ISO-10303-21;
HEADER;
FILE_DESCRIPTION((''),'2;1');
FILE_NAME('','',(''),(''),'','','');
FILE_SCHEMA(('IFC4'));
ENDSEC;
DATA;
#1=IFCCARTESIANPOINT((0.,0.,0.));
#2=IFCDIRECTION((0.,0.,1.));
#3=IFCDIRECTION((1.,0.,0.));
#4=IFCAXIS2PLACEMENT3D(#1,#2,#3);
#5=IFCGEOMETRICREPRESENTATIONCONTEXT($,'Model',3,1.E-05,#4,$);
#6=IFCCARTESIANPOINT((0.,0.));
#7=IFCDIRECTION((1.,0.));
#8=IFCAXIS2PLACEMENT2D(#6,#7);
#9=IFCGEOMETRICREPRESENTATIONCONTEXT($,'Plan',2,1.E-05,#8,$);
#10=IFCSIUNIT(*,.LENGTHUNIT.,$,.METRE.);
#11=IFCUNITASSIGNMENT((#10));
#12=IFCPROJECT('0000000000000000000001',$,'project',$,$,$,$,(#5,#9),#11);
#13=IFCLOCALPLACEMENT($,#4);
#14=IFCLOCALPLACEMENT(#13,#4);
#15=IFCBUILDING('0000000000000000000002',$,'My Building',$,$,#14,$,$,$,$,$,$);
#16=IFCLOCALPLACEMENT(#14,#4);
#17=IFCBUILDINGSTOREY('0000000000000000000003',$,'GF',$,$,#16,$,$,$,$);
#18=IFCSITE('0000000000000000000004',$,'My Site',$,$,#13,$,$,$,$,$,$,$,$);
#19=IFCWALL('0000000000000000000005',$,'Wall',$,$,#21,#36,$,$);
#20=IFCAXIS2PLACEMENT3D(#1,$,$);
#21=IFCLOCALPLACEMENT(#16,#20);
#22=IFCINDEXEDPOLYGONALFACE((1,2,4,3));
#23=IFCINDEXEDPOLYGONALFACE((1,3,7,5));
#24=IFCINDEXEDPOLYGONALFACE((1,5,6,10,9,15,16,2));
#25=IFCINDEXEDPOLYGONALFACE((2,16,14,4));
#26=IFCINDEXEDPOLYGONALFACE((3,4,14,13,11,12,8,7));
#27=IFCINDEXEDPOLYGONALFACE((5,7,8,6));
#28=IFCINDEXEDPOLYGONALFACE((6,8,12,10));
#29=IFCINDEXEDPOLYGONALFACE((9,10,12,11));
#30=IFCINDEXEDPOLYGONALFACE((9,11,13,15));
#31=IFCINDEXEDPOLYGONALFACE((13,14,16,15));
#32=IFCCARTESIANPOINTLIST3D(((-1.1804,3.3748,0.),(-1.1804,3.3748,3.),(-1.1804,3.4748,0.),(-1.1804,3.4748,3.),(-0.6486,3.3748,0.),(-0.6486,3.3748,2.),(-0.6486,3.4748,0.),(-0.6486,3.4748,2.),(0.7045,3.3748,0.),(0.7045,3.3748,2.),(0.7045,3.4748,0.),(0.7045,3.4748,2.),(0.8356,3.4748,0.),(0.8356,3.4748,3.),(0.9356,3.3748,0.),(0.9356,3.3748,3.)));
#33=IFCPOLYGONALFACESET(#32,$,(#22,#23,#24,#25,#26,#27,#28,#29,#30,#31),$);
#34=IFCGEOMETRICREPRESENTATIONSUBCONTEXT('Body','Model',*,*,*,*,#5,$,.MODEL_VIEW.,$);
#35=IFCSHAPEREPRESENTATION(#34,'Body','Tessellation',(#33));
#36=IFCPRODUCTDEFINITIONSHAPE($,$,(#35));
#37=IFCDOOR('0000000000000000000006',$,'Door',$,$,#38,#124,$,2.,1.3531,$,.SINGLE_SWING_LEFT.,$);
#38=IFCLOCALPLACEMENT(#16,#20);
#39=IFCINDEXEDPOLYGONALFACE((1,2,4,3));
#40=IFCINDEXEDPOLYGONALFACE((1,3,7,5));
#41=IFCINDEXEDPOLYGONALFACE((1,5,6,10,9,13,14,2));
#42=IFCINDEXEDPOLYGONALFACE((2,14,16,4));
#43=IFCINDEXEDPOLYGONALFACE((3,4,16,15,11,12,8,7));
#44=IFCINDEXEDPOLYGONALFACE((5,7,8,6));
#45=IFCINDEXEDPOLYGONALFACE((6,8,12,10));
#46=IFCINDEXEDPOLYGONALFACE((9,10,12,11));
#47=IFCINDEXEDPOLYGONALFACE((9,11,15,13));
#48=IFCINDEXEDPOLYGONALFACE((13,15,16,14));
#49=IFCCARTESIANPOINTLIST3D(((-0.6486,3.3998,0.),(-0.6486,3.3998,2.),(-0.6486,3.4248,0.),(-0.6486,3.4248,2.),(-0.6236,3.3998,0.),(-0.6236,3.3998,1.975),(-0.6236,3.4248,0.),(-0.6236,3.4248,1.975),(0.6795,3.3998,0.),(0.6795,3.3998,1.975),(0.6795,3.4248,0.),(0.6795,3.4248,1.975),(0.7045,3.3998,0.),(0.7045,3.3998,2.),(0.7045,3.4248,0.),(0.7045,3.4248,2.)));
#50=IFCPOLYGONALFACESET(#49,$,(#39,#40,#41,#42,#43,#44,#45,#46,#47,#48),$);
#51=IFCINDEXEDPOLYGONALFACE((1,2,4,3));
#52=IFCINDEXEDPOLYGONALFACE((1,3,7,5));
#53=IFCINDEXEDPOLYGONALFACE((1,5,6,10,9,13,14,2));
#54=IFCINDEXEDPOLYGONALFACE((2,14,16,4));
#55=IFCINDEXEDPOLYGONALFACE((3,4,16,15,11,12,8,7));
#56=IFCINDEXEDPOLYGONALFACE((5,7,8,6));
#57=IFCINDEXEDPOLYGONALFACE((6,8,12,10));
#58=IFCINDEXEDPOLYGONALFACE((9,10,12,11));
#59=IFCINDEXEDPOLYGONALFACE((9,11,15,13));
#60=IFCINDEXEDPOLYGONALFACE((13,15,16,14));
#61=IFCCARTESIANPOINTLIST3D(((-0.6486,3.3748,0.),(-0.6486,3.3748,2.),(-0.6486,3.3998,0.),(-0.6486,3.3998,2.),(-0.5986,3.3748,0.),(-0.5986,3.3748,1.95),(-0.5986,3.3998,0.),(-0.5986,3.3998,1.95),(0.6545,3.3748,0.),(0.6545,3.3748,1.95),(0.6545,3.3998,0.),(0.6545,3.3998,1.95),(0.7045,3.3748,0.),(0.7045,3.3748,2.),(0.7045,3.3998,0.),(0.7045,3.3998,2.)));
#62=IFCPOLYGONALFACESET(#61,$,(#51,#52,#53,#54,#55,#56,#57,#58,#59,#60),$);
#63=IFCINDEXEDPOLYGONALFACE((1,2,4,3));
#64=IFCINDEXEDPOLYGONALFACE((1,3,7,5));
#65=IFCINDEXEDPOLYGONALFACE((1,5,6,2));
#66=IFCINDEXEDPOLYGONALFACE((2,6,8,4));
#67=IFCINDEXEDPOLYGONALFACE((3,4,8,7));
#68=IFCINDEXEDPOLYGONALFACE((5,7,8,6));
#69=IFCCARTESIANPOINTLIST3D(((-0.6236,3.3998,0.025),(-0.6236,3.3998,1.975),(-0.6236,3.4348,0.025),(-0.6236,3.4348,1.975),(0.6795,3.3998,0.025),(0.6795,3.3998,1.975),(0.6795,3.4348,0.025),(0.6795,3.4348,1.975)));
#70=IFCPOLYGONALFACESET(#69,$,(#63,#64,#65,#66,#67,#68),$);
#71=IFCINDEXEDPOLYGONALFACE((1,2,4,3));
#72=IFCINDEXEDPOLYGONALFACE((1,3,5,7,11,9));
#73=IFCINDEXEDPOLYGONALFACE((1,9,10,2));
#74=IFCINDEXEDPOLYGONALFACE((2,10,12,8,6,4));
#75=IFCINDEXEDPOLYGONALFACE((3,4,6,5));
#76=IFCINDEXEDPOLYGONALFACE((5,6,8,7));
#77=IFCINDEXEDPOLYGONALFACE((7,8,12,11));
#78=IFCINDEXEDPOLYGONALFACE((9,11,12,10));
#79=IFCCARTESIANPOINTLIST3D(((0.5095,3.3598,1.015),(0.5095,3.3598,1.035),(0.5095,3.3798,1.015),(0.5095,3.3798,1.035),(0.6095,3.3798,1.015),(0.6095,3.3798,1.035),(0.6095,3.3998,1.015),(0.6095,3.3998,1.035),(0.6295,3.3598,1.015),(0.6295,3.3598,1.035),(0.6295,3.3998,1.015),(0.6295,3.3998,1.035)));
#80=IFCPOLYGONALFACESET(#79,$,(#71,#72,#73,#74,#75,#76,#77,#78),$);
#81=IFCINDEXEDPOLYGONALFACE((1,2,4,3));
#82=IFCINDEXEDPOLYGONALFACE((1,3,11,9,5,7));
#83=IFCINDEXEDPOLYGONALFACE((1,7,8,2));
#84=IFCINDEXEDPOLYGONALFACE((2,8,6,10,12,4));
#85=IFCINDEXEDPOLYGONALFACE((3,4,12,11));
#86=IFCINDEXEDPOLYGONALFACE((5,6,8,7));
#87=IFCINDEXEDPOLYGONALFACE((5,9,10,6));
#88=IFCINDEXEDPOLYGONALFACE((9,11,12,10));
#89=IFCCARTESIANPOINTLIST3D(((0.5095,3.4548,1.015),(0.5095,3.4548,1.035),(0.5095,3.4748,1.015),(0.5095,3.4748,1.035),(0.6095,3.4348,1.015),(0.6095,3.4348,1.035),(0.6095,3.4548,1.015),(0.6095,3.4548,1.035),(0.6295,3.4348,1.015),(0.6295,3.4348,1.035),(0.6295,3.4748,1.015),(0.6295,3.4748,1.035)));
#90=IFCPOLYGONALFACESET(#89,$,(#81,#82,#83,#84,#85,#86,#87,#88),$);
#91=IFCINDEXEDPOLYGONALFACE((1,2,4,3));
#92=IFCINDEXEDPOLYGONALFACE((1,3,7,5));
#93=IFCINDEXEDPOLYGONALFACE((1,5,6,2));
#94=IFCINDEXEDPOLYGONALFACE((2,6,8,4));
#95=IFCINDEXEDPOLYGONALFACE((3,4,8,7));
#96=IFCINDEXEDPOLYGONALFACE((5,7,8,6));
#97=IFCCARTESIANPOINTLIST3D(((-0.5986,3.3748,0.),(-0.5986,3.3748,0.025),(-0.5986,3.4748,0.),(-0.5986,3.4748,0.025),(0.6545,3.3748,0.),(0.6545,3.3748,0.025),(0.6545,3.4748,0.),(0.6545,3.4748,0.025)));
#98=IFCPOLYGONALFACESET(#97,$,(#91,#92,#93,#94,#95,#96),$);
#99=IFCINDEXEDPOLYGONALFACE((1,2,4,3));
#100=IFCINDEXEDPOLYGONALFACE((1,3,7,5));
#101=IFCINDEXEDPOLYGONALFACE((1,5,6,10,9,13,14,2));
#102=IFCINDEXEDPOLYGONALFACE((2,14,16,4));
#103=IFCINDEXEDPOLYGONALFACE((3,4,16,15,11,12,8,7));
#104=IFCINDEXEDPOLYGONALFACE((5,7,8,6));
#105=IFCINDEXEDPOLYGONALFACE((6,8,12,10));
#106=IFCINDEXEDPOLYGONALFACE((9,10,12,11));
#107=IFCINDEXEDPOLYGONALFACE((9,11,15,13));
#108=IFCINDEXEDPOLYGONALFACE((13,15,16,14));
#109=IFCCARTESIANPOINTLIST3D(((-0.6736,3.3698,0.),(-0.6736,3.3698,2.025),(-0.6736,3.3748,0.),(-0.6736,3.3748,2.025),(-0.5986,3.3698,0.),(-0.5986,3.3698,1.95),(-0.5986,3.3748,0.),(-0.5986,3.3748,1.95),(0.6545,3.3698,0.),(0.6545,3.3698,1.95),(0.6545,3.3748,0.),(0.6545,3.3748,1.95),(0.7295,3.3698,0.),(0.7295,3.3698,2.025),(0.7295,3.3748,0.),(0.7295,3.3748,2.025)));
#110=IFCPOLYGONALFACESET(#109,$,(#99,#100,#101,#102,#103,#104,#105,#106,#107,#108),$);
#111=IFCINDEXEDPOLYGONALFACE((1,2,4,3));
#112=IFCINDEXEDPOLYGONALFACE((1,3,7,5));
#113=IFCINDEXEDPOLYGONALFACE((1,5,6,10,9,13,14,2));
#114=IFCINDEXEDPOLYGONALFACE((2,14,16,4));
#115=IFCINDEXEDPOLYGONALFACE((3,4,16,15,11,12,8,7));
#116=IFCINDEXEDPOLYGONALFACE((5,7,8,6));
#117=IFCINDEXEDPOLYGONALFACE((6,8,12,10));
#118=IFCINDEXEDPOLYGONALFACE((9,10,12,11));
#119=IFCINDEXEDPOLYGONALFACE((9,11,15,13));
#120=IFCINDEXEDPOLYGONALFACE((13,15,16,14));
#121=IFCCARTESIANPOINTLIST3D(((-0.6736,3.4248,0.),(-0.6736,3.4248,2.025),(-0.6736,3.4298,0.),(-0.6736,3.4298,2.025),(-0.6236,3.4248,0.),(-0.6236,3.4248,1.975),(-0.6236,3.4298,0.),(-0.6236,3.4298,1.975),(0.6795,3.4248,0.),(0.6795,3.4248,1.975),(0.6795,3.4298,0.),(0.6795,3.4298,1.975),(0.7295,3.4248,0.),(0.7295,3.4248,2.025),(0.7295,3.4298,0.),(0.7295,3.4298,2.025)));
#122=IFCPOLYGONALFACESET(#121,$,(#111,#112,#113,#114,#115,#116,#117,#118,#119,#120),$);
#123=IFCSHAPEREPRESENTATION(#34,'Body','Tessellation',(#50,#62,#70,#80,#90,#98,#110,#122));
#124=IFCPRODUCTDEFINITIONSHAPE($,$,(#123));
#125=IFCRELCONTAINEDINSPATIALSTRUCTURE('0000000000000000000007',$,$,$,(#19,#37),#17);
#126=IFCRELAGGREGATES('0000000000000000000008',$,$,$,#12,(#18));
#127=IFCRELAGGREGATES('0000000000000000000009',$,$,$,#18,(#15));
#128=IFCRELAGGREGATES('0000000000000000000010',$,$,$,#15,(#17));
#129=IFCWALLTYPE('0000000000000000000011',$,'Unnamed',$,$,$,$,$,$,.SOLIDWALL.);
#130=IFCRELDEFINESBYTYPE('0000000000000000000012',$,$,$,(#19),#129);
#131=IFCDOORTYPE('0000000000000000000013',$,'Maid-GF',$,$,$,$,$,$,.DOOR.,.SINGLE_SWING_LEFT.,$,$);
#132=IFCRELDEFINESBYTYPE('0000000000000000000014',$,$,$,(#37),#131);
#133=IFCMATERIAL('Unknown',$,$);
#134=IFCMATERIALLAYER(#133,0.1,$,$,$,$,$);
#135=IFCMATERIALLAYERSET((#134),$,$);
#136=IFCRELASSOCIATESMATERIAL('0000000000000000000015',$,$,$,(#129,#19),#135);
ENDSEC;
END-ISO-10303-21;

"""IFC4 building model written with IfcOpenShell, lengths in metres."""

from ifc_helpers import new_model, entity, si_unit, frame, origin_with_axes, origin_2d_with_axis, place, context, subcontext, project, spatial, line, indexed_curve, outline, extrude, shape, source, transform, mapped, material, layer, layer_set, layer_usage, type_object, type_shapes, element, fill, save


model = new_model("IFC4")

# Units and contexts
model_context = context("Model", 3, precision=1e-05, world=origin_with_axes())
plan_context = context("Plan", 2, precision=1e-05, world=origin_2d_with_axis())
body_context_1 = subcontext(model_context, "Body", "Model", "MODEL_VIEW")
body_context_2 = subcontext(plan_context, "Body", "Plan", "PLAN_VIEW")
ifc_project = project(units=[si_unit("LENGTHUNIT", "METRE")], contexts=[model_context, plan_context])

# Site, building, storey
site_placement = place(None, origin_with_axes())
site = spatial("IfcSite", under=ifc_project, at=site_placement, Name="My Site")
building_placement = place(site_placement, origin_with_axes())
building = spatial("IfcBuilding", under=site, at=building_placement, Name="My Building")
storey_placement = place(building_placement, origin_with_axes())
storey = spatial("IfcBuildingStorey", under=building, at=storey_placement, Name="GF")

# Shared definitions
ifc_material = material(Name="Unknown")

# Shared definitions
ifc_layer_1 = layer(ifc_material, 0.1)
ifc_layer_set_1 = layer_set([ifc_layer_1])
wall_type = type_object("IfcWallType", Name="Unnamed", PredefinedType="SOLIDWALL", material=ifc_layer_set_1)

# Wall, opening, door
ifc_layer_usage_1 = layer_usage(ifc_layer_set_1, "AXIS2", "POSITIVE", 0.0)
wall_1_placement = place(storey_placement, frame((0.8356, 3.4748, 0.0), z_axis=(0.0, 0.0, 1.0), x_axis=(-1.0, 0.0, 0.0)))
wall_1 = element("IfcWall", 1, at=wall_1_placement, inside=storey, type_object=wall_type, material=ifc_layer_usage_1, Name="Wall", context=body_context_1, shape_type="SweptSolid", body=[
    extrude(outline(indexed_curve([(0.0, 0.0), (-0.1, 0.1), (2.016, 0.1), (2.016, 0.0)], segments=[line(1, 2, 3, 4, 1)])), origin_with_axes(), (0.0, 0.0, 1.0), 3.0),
])
shared_shape_1 = source(origin_with_axes(), body_context_1, "Body", "SweptSolid", [
    extrude(outline(indexed_curve([(0.0, 0.0), (1.3531, 0.0), (1.3531, 2.0), (0.0, 2.0)], segments=[line(1, 2, 3, 4, 1)])), frame((0.0, -0.6, 0.0), z_axis=(0.0, -1.0, 0.0), x_axis=(1.0, 0.0, 0.0)), (0.0, 0.0, -1.0), 1.2),
])
opening_1_placement = place(wall_1_placement, frame((1.4842, 0.1, 0.0), z_axis=(0.0, 0.0, 1.0), x_axis=(-1.0, 0.000001, 0.0)))
opening_1 = element("IfcOpeningElement", 2, at=opening_1_placement, cuts=wall_1, PredefinedType="OPENING", context=body_context_1, shape_type="MappedRepresentation", body=[
    mapped(shared_shape_1, transform((0.0, 0.0, 0.0), x_axis=(1.0, 0.0, 0.0), y_axis=(0.0, 1.0, 0.0), z_axis=(0.0, 0.0, 1.0), scale=1.0)),
])
door_type_1 = type_object("IfcDoorType", Name="Maid-GF", OperationType="SINGLE_SWING_LEFT", PredefinedType="DOOR")
shared_shape_2 = source(origin_with_axes(), body_context_1, "Body", "SweptSolid", [
    extrude(outline(indexed_curve([(0.0, 0.0), (0.0, 2.0), (1.3531, 2.0), (1.3531, 0.0), (1.3281, 0.0), (1.3281, 1.975), (0.025, 1.975), (0.025, 0.0)], segments=[line(1, 2, 3, 4, 5, 6, 7, 8, 1)])), frame((0.0, 0.025, 0.0), z_axis=(0.0, -1.0, 0.0), x_axis=(1.0, 0.0, 0.0)), (0.0, 0.0, -1.0), 0.025),
    extrude(outline(indexed_curve([(0.0, 0.0), (0.0, 2.0), (1.3531, 2.0), (1.3531, 0.0), (1.3031, 0.0), (1.3031, 1.95), (0.05, 1.95), (0.05, 0.0)], segments=[line(1, 2, 3, 4, 5, 6, 7, 8, 1)])), frame((0.0, 0.0, 0.0), z_axis=(0.0, -1.0, 0.0), x_axis=(1.0, 0.0, 0.0)), (0.0, 0.0, -1.0), 0.025),
    extrude(outline(indexed_curve([(0.0, 0.0), (1.3031, 0.0), (1.3031, 0.035), (0.0, 0.035)], segments=[line(1, 2, 3, 4, 1)])), frame((0.025, 0.025, 0.025), z_axis=(0.0, 0.0, 1.0), x_axis=(1.0, 0.0, 0.0)), (0.0, 0.0, 1.0), 1.95),
    extrude(outline(indexed_curve([(0.0, 0.0), (0.0, -0.04), (-0.12, -0.04), (-0.12, -0.02), (-0.02, -0.02), (-0.02, 0.0)], segments=[line(1, 2, 3, 4, 5, 6, 1)])), frame((1.2781, 0.025, 1.015), z_axis=(0.0, 0.0, 1.0), x_axis=(1.0, 0.0, 0.0)), (0.0, 0.0, 1.0), 0.02),
    extrude(outline(indexed_curve([(0.0, 0.0), (0.0, 0.04), (-0.12, 0.04), (-0.12, 0.02), (-0.02, 0.02), (-0.02, 0.0)], segments=[line(1, 2, 3, 4, 5, 6, 1)])), frame((1.2781, 0.06, 1.015), z_axis=(0.0, 0.0, 1.0), x_axis=(1.0, 0.0, 0.0)), (0.0, 0.0, 1.0), 0.02),
    extrude(outline(indexed_curve([(0.0, 0.0), (1.2531, 0.0), (1.2531, 0.1), (0.0, 0.1)], segments=[line(1, 2, 3, 4, 1)])), frame((0.05, 0.0, 0.0), z_axis=(0.0, 0.0, 1.0), x_axis=(1.0, 0.0, 0.0)), (0.0, 0.0, 1.0), 0.025),
    extrude(outline(indexed_curve([(0.0, 0.0), (0.0, 2.025), (1.4031, 2.025), (1.4031, 0.0), (1.3281, 0.0), (1.3281, 1.95), (0.075, 1.95), (0.075, 0.0)], segments=[line(1, 2, 3, 4, 5, 6, 7, 8, 1)])), frame((-0.025, -0.005, 0.0), z_axis=(0.0, -1.0, 0.0), x_axis=(1.0, 0.0, 0.0)), (0.0, 0.0, -1.0), 0.005),
    extrude(outline(indexed_curve([(0.0, 0.0), (0.0, 2.025), (1.4031, 2.025), (1.4031, 0.0), (1.3531, 0.0), (1.3531, 1.975), (0.05, 1.975), (0.05, 0.0)], segments=[line(1, 2, 3, 4, 5, 6, 7, 8, 1)])), frame((-0.025, 0.05, 0.0), z_axis=(0.0, -1.0, 0.0), x_axis=(1.0, 0.0, 0.0)), (0.0, 0.0, -1.0), 0.005),
])
shared_shape_3 = source(origin_with_axes(), body_context_2, "Body", "Curve2D", [
    entity("IfcIndexedPolyCurve", entity("IfcCartesianPointList2D", [[0.0, 0.0], [0.0, 0.05], [0.025, 0.05], [0.025, 0.025], [0.05, 0.025], [0.05, 0.0]]), [entity("IfcLineIndex", [1, 2, 3, 4, 5, 6, 1])]),
    entity("IfcIndexedPolyCurve", entity("IfcCartesianPointList2D", [[1.3531, 0.0], [1.3531, 0.05], [1.3281, 0.05], [1.3281, 0.025], [1.3031, 0.025], [1.3031, 0.0]]), [entity("IfcLineIndex", [1, 2, 3, 4, 5, 6, 1])]),
    entity("IfcTrimmedCurve", entity("IfcEllipse", entity("IfcAxis2Placement2D", entity("IfcCartesianPoint", [0.06, 0.05]), entity("IfcDirection", [1.0, 0.0])), 1.2681, 1.3031), [entity("IfcCartesianPoint", [1.3281, 0.05])], [entity("IfcCartesianPoint", [0.06, 1.3531])], True, "CARTESIAN"),
    entity("IfcIndexedPolyCurve", entity("IfcCartesianPointList2D", [[0.025, 0.05], [0.06, 0.05], [0.06, 1.3531], [0.025, 1.3531]]), [entity("IfcLineIndex", [1, 2, 3, 4, 1])]),
])
type_shapes(door_type_1, [shared_shape_2, shared_shape_3])
door_1_placement = place(opening_1_placement, frame((0.0, 0.0, 0.0), z_axis=(0.0, 0.0, 1.0), x_axis=(1.0, 0.0, 0.0)))
door_1 = element("IfcDoor", 3, at=door_1_placement, inside=storey, type_object=door_type_1, Name="Door", OperationType="SINGLE_SWING_LEFT", OverallHeight=2.0, OverallWidth=1.3531, shapes=[
    shape(body_context_1, "Body", "MappedRepresentation", [mapped(shared_shape_2, transform((0.0, 0.0, 0.0), x_axis=(1.0, 0.0, 0.0), y_axis=(0.0, 1.0, 0.0), z_axis=(0.0, 0.0, 1.0), scale=1.0))]),
    shape(body_context_2, "Body", "MappedRepresentation", [mapped(shared_shape_3, transform((0.0, 0.0, 0.0), x_axis=(1.0, 0.0, 0.0), y_axis=(0.0, 1.0, 0.0), z_axis=(0.0, 0.0, 1.0), scale=1.0))]),
])
fill(opening_1, door_1)

save(model, "model.ifc")
